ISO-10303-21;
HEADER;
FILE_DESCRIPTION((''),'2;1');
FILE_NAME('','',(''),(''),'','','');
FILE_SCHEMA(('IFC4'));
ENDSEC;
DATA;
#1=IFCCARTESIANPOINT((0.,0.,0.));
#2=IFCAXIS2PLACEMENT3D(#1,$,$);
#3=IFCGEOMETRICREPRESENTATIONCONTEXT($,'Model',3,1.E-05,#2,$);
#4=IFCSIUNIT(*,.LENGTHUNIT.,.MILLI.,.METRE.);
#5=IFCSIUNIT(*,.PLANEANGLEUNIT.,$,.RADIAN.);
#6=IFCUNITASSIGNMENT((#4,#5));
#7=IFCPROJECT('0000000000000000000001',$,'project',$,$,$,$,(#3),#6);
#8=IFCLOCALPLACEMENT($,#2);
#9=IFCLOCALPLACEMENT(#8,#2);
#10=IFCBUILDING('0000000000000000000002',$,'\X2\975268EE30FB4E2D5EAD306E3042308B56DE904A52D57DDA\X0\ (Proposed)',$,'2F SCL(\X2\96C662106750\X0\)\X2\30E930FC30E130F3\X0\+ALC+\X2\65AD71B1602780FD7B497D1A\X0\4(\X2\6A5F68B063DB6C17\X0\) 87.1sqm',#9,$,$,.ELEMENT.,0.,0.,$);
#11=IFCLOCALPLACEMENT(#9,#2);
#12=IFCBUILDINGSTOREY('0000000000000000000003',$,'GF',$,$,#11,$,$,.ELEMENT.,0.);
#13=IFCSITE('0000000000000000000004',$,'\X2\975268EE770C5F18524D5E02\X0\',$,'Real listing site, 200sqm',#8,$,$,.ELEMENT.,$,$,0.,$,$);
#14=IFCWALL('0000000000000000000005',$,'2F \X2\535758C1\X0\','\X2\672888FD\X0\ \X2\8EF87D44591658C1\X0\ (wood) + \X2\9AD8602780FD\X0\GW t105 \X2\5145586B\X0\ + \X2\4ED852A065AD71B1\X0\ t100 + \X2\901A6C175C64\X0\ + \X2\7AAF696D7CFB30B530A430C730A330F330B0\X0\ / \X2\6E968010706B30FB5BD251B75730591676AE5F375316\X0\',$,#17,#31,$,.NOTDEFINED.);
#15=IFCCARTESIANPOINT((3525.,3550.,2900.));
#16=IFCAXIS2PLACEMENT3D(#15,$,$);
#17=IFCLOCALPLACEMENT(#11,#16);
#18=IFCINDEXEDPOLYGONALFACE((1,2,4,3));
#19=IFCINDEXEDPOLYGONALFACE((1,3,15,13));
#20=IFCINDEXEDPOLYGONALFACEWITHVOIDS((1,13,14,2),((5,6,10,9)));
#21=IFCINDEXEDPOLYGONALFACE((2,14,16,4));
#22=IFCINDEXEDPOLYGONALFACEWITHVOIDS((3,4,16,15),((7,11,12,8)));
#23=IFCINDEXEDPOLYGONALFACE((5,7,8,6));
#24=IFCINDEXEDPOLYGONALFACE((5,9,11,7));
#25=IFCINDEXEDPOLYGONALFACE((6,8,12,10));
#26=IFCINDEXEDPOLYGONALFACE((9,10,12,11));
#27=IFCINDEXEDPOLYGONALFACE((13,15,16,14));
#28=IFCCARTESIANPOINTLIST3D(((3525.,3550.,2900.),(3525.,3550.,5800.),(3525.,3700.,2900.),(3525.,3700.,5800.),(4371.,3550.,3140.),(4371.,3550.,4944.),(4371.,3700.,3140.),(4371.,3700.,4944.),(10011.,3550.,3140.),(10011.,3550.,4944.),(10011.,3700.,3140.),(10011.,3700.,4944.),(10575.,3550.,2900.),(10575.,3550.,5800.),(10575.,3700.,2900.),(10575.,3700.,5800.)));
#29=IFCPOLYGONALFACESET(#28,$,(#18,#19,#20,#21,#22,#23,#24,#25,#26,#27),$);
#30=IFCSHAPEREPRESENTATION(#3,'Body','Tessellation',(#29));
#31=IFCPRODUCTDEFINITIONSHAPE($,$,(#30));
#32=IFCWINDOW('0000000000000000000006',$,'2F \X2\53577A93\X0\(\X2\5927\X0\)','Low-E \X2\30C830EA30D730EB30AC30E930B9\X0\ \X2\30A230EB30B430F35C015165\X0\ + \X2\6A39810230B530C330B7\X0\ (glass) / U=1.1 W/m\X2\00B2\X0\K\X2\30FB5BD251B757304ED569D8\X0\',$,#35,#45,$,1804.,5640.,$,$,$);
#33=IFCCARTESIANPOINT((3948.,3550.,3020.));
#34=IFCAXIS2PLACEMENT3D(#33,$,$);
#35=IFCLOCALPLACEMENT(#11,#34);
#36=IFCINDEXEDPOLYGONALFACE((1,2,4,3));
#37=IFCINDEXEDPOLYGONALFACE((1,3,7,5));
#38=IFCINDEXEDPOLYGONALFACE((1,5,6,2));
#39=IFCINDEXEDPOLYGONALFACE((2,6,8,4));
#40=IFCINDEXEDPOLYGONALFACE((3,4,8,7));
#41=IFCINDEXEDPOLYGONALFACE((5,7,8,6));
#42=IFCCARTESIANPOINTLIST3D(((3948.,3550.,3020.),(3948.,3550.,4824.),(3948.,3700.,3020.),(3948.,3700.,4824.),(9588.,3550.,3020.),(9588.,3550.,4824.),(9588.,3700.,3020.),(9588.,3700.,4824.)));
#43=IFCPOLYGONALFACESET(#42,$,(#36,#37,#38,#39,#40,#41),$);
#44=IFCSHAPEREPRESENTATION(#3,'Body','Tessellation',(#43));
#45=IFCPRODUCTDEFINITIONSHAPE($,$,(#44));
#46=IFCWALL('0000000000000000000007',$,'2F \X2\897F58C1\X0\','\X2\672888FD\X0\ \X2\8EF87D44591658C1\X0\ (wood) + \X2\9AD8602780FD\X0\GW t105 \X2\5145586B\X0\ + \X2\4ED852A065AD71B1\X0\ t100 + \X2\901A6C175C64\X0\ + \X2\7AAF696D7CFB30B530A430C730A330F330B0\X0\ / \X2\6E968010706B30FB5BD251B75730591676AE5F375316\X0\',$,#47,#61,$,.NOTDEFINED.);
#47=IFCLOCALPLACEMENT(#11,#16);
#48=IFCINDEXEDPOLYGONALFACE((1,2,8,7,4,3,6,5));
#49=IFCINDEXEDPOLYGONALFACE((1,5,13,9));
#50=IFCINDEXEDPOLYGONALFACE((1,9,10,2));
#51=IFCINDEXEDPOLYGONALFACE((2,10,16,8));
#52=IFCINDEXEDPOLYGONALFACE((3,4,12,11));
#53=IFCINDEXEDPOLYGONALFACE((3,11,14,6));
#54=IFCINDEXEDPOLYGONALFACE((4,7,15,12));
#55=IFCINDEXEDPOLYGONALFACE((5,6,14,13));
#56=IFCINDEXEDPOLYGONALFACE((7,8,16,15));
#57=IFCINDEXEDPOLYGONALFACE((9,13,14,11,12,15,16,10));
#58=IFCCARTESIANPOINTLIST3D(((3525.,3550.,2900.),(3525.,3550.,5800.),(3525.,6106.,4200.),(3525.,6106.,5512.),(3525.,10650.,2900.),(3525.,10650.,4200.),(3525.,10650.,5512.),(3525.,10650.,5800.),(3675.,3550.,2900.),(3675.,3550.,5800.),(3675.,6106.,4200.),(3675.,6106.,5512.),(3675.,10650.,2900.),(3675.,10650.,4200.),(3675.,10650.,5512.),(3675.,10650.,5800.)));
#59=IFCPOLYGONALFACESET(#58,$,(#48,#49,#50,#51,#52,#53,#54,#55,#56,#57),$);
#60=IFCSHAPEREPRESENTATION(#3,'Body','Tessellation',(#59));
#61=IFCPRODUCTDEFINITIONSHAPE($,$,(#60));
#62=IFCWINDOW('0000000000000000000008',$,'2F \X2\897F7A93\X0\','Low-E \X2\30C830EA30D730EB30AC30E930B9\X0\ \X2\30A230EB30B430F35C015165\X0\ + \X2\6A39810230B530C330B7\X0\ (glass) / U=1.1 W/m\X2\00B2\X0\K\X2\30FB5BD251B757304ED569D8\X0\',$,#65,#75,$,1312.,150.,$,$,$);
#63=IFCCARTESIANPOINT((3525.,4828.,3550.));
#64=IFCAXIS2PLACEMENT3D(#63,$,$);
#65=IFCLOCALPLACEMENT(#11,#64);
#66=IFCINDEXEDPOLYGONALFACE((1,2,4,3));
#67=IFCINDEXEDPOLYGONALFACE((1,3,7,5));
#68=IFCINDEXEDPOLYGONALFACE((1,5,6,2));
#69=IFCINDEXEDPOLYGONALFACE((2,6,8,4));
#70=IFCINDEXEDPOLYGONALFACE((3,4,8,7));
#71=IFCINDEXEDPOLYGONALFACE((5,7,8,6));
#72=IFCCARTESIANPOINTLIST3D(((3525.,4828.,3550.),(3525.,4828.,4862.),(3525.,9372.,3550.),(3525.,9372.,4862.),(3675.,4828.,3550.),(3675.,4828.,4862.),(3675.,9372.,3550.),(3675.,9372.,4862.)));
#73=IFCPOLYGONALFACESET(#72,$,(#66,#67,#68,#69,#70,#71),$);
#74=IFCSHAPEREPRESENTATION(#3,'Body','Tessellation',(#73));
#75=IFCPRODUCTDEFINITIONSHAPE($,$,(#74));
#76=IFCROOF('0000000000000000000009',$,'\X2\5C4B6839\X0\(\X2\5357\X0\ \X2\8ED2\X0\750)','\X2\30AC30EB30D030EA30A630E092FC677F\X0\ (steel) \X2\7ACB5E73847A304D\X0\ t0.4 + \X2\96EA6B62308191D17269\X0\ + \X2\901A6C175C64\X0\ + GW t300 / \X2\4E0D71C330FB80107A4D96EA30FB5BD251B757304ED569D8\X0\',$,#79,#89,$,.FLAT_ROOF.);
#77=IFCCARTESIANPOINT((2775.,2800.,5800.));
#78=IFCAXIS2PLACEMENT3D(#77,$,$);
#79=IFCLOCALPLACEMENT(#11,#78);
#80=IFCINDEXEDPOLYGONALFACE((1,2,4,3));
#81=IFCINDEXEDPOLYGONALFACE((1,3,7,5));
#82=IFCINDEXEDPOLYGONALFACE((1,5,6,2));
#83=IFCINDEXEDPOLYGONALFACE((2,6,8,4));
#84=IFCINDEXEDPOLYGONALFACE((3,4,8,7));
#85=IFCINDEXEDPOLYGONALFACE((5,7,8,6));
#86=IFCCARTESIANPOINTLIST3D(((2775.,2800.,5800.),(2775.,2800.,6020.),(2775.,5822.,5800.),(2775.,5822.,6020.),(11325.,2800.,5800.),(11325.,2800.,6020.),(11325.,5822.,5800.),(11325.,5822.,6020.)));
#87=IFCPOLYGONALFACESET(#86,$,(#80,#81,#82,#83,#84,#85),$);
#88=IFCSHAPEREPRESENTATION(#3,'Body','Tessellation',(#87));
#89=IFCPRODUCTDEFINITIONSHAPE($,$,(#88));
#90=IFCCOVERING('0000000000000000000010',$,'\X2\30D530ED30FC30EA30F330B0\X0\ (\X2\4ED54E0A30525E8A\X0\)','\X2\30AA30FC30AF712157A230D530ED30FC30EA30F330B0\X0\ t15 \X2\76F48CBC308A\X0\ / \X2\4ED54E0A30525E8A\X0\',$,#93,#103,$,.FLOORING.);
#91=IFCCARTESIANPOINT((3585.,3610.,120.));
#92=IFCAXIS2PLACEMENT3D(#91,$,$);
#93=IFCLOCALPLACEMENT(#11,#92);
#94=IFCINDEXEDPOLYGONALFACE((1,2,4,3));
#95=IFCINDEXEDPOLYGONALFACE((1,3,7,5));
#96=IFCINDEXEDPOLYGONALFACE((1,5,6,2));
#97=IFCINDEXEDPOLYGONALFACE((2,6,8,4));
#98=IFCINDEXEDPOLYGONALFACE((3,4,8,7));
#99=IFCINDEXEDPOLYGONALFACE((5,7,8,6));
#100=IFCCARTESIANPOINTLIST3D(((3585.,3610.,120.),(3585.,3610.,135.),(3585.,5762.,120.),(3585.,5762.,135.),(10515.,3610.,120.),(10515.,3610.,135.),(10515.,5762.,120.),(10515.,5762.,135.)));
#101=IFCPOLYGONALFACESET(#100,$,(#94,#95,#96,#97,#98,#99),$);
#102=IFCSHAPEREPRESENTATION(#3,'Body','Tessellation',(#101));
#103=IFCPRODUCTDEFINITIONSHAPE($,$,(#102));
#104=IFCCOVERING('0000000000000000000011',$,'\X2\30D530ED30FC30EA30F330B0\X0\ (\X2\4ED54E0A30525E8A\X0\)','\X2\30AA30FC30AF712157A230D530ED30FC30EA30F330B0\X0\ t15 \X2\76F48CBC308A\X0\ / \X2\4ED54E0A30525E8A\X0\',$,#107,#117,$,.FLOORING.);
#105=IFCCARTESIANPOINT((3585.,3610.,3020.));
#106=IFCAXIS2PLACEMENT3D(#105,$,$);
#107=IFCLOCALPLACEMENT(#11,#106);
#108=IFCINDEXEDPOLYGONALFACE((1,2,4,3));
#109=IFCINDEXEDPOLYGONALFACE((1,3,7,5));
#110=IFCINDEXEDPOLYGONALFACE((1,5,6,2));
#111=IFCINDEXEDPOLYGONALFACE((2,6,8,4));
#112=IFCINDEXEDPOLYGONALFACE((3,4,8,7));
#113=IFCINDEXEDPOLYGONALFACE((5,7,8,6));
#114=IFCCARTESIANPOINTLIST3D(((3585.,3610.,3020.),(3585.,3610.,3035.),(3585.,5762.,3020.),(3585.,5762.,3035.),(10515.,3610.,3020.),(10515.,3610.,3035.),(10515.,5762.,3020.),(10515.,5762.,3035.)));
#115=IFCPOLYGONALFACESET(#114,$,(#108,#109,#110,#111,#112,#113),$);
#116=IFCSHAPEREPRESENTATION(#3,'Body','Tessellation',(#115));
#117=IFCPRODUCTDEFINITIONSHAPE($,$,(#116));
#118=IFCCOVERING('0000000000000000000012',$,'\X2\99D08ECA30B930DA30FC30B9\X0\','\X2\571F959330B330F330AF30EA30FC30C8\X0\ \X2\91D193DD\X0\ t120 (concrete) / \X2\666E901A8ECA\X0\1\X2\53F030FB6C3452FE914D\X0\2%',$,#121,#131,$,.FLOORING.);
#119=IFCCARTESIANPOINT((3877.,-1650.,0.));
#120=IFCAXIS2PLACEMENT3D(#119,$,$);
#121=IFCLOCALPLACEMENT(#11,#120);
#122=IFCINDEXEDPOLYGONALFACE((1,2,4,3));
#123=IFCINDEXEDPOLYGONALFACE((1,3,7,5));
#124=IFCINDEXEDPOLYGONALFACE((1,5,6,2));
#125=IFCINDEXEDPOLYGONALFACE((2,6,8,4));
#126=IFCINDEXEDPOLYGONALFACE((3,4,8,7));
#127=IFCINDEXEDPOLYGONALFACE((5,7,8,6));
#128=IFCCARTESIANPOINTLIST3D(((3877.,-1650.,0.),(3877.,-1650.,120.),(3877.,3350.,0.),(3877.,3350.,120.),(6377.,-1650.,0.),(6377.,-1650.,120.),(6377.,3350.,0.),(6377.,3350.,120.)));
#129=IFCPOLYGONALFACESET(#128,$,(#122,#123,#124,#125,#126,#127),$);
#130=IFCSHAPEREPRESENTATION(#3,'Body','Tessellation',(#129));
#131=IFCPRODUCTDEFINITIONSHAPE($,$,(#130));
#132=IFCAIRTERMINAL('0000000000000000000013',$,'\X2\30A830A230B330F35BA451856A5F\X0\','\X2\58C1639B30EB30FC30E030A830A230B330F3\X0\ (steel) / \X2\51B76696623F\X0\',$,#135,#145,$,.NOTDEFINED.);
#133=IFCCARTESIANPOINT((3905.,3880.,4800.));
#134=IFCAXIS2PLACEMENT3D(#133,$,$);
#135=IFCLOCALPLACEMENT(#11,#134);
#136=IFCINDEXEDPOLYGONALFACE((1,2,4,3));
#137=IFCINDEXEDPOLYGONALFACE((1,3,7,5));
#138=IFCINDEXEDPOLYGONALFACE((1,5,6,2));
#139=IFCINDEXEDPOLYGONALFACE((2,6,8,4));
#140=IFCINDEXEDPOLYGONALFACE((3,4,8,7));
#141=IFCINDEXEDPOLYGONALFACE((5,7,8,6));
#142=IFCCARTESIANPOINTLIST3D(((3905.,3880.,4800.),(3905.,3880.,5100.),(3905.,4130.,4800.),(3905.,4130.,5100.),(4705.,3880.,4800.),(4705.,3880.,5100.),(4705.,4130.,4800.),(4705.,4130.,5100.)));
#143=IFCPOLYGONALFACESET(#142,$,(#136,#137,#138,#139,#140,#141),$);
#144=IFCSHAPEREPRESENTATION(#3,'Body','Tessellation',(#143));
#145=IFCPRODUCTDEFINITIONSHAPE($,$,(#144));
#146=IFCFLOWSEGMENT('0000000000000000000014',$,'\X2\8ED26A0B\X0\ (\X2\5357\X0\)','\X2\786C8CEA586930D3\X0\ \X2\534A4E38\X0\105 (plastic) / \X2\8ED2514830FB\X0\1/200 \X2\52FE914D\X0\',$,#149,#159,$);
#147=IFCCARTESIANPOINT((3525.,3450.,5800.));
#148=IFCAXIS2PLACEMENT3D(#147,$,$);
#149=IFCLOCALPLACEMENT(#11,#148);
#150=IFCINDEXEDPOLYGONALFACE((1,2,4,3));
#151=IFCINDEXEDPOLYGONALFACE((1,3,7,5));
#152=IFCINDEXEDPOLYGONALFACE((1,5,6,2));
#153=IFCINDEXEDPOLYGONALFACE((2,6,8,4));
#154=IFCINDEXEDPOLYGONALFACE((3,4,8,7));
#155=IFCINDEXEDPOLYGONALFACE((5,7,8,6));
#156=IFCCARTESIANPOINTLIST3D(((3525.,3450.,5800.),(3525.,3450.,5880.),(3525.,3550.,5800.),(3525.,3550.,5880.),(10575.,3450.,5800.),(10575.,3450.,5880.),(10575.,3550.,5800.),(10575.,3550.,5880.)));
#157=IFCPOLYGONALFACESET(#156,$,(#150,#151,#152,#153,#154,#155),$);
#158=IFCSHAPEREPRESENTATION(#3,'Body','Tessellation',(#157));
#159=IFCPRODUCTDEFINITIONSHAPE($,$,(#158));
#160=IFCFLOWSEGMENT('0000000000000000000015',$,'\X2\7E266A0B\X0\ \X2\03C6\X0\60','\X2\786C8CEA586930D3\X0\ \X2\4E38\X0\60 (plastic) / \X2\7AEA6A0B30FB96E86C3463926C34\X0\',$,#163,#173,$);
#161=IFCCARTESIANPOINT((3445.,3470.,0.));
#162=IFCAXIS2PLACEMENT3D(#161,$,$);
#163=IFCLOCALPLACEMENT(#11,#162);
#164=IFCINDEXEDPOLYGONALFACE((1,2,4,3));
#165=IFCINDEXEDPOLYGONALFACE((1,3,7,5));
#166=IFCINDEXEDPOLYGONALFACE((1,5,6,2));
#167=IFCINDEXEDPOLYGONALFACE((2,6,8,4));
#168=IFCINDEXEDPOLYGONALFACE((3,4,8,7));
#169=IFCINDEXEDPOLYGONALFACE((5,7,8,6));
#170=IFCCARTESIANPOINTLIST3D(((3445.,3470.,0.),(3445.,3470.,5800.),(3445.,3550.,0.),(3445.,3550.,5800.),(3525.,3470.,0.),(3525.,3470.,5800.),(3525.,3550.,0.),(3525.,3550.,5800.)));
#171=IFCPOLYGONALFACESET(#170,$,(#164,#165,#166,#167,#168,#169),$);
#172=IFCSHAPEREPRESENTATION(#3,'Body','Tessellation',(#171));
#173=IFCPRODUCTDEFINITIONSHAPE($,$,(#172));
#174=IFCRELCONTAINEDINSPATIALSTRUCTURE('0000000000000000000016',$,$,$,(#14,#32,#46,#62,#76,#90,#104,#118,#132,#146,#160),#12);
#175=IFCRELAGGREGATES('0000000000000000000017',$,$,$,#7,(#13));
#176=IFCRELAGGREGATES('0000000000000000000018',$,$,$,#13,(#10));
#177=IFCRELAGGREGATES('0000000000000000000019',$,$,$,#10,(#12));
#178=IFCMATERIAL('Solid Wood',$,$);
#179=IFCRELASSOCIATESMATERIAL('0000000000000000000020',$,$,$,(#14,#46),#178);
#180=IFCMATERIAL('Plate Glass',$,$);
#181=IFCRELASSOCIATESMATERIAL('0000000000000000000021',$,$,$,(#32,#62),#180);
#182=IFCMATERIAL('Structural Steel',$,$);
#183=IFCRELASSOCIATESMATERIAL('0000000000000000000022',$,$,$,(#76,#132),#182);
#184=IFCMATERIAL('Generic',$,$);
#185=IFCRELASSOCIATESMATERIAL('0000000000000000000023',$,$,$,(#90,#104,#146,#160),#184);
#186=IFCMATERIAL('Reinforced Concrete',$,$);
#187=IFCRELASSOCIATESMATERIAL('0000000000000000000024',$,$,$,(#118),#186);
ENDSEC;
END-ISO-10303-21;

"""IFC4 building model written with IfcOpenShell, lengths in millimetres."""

from ifc_helpers import new_model, si_unit, frame, frame_2d, origin, place, context, project, spatial, rectangle, extrude, material, element, fill, save


model = new_model("IFC4")

# Units and contexts
model_context = context("Model", 3, precision=1e-05, world=origin())
ifc_project = project(units=[si_unit("LENGTHUNIT", "METRE", prefix="MILLI"), si_unit("PLANEANGLEUNIT", "RADIAN")], contexts=[model_context])

# Site, building, storey
site_placement = place(None, origin())
site = spatial("IfcSite", under=ifc_project, at=site_placement, Name="青森県弘前市", ObjectType="Real listing site, 200sqm", CompositionType="ELEMENT", RefElevation=0.0)
building_placement = place(site_placement, origin())
building = spatial("IfcBuilding", under=site, at=building_placement, Name="青森・中庭のある回遊動線 (Proposed)", ObjectType="2F SCL(集成材)ラーメン+ALC+断熱性能等級4(機械換気) 87.1sqm", CompositionType="ELEMENT", ElevationOfRefHeight=0.0, ElevationOfTerrain=0.0)
storey_placement = place(building_placement, origin())
storey = spatial("IfcBuildingStorey", under=building, at=storey_placement, Name="GF", CompositionType="ELEMENT", Elevation=0.0)

# Shared definitions
ifc_material_1 = material(Name="Solid Wood")

# Shared definitions
ifc_material_2 = material(Name="Reinforced Concrete")

# Shared definitions
ifc_material_3 = material(Name="Plate Glass")

# Walls, openings, windows
wall_1_placement = place(storey_placement, frame((3525.0, 3550.0, 2900.0)))
wall_1 = element("IfcWall", 1, at=wall_1_placement, inside=storey, material=ifc_material_1, Name="2F 南壁", Description="木製 軸組外壁 (wood) + 高性能GW t105 充填 + 付加断熱 t100 + 通気層 + 窯業系サイディング / 準耐火・寒冷地外皮強化", PredefinedType="NOTDEFINED", context=model_context, shape_type="SweptSolid", body=[
    extrude(rectangle(XDim=7050.0, YDim=150.0, at=frame_2d((3525.0, 75.0))), frame((3525.0, 3550.0, 2900.0)), (0.0, 0.0, 1.0), 2900.0),
])
opening_1_placement = place(storey_placement, frame((3948.0, 3550.0, 3020.0)))
opening_1 = element("IfcOpeningElement", 2, at=opening_1_placement, cuts=wall_1, PredefinedType="NOTDEFINED", context=model_context, shape_type="SweptSolid", body=[
    extrude(rectangle(XDim=5640.0, YDim=150.0, at=frame_2d((2820.0, 75.0))), frame((3948.0, 3550.0, 3020.0)), (0.0, 0.0, 1.0), 1804.0),
])
window_1_placement = place(storey_placement, frame((3948.0, 3550.0, 3020.0)))
window_1 = element("IfcWindow", 3, at=window_1_placement, inside=storey, material=ifc_material_3, Name="2F 南窓(大)", Description="Low-E トリプルガラス アルゴン封入 + 樹脂サッシ (glass) / U=1.1 W/m²K・寒冷地仕様", OverallHeight=1804.0, OverallWidth=5640.0, context=model_context, shape_type="SweptSolid", body=[
    extrude(rectangle(XDim=5640.0, YDim=150.0, at=frame_2d((2820.0, 75.0))), frame((3948.0, 3550.0, 3020.0)), (0.0, 0.0, 1.0), 1804.0),
])
fill(opening_1, window_1)
wall_2_placement = place(storey_placement, frame((3525.0, 3550.0, 2900.0)))
wall_2 = element("IfcWall", 4, at=wall_2_placement, inside=storey, material=ifc_material_1, Name="2F 西壁", Description="木製 軸組外壁 (wood) + 高性能GW t105 充填 + 付加断熱 t100 + 通気層 + 窯業系サイディング / 準耐火・寒冷地外皮強化", PredefinedType="NOTDEFINED", context=model_context, shape_type="SweptSolid", body=[
    extrude(rectangle(XDim=150.0, YDim=7100.0, at=frame_2d((75.0, 3550.0))), frame((3525.0, 3550.0, 2900.0)), (0.0, 0.0, 1.0), 2900.0),
])
opening_2_placement = place(storey_placement, frame((3525.0, 4828.0, 3550.0)))
opening_2 = element("IfcOpeningElement", 5, at=opening_2_placement, cuts=wall_2, PredefinedType="NOTDEFINED", context=model_context, shape_type="SweptSolid", body=[
    extrude(rectangle(XDim=150.0, YDim=4544.0, at=frame_2d((75.0, 2272.0))), frame((3525.0, 4828.0, 3550.0)), (0.0, 0.0, 1.0), 1312.0),
])
window_2_placement = place(storey_placement, frame((3525.0, 4828.0, 3550.0)))
window_2 = element("IfcWindow", 6, at=window_2_placement, inside=storey, material=ifc_material_3, Name="2F 西窓", Description="Low-E トリプルガラス アルゴン封入 + 樹脂サッシ (glass) / U=1.1 W/m²K・寒冷地仕様", OverallHeight=1312.0, OverallWidth=150.0, context=model_context, shape_type="SweptSolid", body=[
    extrude(rectangle(XDim=150.0, YDim=4544.0, at=frame_2d((75.0, 2272.0))), frame((3525.0, 4828.0, 3550.0)), (0.0, 0.0, 1.0), 1312.0),
])
fill(opening_2, window_2)

# Roof
ifc_material_4 = material(Name="Structural Steel")
for number, where, name in (
    (7, (2775.0, 2800.0, 5800.0), "屋根(南 軒750)"),
):
    element("IfcRoof", number, at=place(storey_placement, frame(where)), inside=storey, material=ifc_material_4, Name=name, Description="ガルバリウム鋼板 (steel) 立平葺き t0.4 + 雪止め金物 + 通気層 + GW t300 / 不燃・耐積雪・寒冷地仕様", PredefinedType="FLAT_ROOF", context=model_context, shape_type="SweptSolid", body=[
        extrude(rectangle(XDim=8550.0, YDim=3022.0, at=frame_2d((4275.0, 1511.0))), frame((2775.0, 2800.0, 5800.0)), (0.0, 0.0, 1.0), 220.0),
    ])

# Coverings
ifc_material_5 = material(Name="Generic")
covering_1_placement = place(storey_placement, frame((3585.0, 3610.0, 120.0)))
element("IfcCovering", 8, at=covering_1_placement, inside=storey, material=ifc_material_5, Name="フローリング (仕上げ床)", Description="オーク無垢フローリング t15 直貼り / 仕上げ床", PredefinedType="FLOORING", context=model_context, shape_type="SweptSolid", body=[
    extrude(rectangle(XDim=6930.0, YDim=2152.0, at=frame_2d((3465.0, 1076.0))), frame((3585.0, 3610.0, 120.0)), (0.0, 0.0, 1.0), 15.0),
])
covering_2_placement = place(storey_placement, frame((3585.0, 3610.0, 3020.0)))
element("IfcCovering", 9, at=covering_2_placement, inside=storey, material=ifc_material_5, Name="フローリング (仕上げ床)", Description="オーク無垢フローリング t15 直貼り / 仕上げ床", PredefinedType="FLOORING", context=model_context, shape_type="SweptSolid", body=[
    extrude(rectangle(XDim=6930.0, YDim=2152.0, at=frame_2d((3465.0, 1076.0))), frame((3585.0, 3610.0, 3020.0)), (0.0, 0.0, 1.0), 15.0),
])
covering_3_placement = place(storey_placement, frame((3877.0, -1650.0, 0.0)))
element("IfcCovering", 10, at=covering_3_placement, inside=storey, material=ifc_material_2, Name="駐車スペース", Description="土間コンクリート 金鏝 t120 (concrete) / 普通車1台・水勾配2%", PredefinedType="FLOORING", context=model_context, shape_type="SweptSolid", body=[
    extrude(rectangle(XDim=2500.0, YDim=5000.0, at=frame_2d((1250.0, 2500.0))), frame((3877.0, -1650.0, 0.0)), (0.0, 0.0, 1.0), 120.0),
])

# Air terminal
air_terminal_placement = place(storey_placement, frame((3905.0, 3880.0, 4800.0)))
element("IfcAirTerminal", 11, at=air_terminal_placement, inside=storey, material=ifc_material_4, Name="エアコン室内機", Description="壁掛ルームエアコン (steel) / 冷暖房", PredefinedType="NOTDEFINED", context=model_context, shape_type="SweptSolid", body=[
    extrude(rectangle(XDim=800.0, YDim=250.0, at=frame_2d((400.0, 125.0))), frame((3905.0, 3880.0, 4800.0)), (0.0, 0.0, 1.0), 300.0),
])

# Flow segments
flow_segment_1_placement = place(storey_placement, frame((3525.0, 3450.0, 5800.0)))
element("IfcFlowSegment", 12, at=flow_segment_1_placement, inside=storey, material=ifc_material_5, Name="軒樋 (南)", Description="硬質塩ビ 半丸105 (plastic) / 軒先・1/200 勾配", context=model_context, shape_type="SweptSolid", body=[
    extrude(rectangle(XDim=7050.0, YDim=100.0, at=frame_2d((3525.0, 50.0))), frame((3525.0, 3450.0, 5800.0)), (0.0, 0.0, 1.0), 80.0),
])
flow_segment_2_placement = place(storey_placement, frame((3445.0, 3470.0, 0.0)))
element("IfcFlowSegment", 13, at=flow_segment_2_placement, inside=storey, material=ifc_material_5, Name="縦樋 φ60", Description="硬質塩ビ 丸60 (plastic) / 竪樋・雨水排水", context=model_context, shape_type="SweptSolid", body=[
    extrude(rectangle(XDim=80.0, YDim=80.0, at=frame_2d((40.0, 40.0))), frame((3445.0, 3470.0, 0.0)), (0.0, 0.0, 1.0), 5800.0),
])

save(model, "model.ifc")
